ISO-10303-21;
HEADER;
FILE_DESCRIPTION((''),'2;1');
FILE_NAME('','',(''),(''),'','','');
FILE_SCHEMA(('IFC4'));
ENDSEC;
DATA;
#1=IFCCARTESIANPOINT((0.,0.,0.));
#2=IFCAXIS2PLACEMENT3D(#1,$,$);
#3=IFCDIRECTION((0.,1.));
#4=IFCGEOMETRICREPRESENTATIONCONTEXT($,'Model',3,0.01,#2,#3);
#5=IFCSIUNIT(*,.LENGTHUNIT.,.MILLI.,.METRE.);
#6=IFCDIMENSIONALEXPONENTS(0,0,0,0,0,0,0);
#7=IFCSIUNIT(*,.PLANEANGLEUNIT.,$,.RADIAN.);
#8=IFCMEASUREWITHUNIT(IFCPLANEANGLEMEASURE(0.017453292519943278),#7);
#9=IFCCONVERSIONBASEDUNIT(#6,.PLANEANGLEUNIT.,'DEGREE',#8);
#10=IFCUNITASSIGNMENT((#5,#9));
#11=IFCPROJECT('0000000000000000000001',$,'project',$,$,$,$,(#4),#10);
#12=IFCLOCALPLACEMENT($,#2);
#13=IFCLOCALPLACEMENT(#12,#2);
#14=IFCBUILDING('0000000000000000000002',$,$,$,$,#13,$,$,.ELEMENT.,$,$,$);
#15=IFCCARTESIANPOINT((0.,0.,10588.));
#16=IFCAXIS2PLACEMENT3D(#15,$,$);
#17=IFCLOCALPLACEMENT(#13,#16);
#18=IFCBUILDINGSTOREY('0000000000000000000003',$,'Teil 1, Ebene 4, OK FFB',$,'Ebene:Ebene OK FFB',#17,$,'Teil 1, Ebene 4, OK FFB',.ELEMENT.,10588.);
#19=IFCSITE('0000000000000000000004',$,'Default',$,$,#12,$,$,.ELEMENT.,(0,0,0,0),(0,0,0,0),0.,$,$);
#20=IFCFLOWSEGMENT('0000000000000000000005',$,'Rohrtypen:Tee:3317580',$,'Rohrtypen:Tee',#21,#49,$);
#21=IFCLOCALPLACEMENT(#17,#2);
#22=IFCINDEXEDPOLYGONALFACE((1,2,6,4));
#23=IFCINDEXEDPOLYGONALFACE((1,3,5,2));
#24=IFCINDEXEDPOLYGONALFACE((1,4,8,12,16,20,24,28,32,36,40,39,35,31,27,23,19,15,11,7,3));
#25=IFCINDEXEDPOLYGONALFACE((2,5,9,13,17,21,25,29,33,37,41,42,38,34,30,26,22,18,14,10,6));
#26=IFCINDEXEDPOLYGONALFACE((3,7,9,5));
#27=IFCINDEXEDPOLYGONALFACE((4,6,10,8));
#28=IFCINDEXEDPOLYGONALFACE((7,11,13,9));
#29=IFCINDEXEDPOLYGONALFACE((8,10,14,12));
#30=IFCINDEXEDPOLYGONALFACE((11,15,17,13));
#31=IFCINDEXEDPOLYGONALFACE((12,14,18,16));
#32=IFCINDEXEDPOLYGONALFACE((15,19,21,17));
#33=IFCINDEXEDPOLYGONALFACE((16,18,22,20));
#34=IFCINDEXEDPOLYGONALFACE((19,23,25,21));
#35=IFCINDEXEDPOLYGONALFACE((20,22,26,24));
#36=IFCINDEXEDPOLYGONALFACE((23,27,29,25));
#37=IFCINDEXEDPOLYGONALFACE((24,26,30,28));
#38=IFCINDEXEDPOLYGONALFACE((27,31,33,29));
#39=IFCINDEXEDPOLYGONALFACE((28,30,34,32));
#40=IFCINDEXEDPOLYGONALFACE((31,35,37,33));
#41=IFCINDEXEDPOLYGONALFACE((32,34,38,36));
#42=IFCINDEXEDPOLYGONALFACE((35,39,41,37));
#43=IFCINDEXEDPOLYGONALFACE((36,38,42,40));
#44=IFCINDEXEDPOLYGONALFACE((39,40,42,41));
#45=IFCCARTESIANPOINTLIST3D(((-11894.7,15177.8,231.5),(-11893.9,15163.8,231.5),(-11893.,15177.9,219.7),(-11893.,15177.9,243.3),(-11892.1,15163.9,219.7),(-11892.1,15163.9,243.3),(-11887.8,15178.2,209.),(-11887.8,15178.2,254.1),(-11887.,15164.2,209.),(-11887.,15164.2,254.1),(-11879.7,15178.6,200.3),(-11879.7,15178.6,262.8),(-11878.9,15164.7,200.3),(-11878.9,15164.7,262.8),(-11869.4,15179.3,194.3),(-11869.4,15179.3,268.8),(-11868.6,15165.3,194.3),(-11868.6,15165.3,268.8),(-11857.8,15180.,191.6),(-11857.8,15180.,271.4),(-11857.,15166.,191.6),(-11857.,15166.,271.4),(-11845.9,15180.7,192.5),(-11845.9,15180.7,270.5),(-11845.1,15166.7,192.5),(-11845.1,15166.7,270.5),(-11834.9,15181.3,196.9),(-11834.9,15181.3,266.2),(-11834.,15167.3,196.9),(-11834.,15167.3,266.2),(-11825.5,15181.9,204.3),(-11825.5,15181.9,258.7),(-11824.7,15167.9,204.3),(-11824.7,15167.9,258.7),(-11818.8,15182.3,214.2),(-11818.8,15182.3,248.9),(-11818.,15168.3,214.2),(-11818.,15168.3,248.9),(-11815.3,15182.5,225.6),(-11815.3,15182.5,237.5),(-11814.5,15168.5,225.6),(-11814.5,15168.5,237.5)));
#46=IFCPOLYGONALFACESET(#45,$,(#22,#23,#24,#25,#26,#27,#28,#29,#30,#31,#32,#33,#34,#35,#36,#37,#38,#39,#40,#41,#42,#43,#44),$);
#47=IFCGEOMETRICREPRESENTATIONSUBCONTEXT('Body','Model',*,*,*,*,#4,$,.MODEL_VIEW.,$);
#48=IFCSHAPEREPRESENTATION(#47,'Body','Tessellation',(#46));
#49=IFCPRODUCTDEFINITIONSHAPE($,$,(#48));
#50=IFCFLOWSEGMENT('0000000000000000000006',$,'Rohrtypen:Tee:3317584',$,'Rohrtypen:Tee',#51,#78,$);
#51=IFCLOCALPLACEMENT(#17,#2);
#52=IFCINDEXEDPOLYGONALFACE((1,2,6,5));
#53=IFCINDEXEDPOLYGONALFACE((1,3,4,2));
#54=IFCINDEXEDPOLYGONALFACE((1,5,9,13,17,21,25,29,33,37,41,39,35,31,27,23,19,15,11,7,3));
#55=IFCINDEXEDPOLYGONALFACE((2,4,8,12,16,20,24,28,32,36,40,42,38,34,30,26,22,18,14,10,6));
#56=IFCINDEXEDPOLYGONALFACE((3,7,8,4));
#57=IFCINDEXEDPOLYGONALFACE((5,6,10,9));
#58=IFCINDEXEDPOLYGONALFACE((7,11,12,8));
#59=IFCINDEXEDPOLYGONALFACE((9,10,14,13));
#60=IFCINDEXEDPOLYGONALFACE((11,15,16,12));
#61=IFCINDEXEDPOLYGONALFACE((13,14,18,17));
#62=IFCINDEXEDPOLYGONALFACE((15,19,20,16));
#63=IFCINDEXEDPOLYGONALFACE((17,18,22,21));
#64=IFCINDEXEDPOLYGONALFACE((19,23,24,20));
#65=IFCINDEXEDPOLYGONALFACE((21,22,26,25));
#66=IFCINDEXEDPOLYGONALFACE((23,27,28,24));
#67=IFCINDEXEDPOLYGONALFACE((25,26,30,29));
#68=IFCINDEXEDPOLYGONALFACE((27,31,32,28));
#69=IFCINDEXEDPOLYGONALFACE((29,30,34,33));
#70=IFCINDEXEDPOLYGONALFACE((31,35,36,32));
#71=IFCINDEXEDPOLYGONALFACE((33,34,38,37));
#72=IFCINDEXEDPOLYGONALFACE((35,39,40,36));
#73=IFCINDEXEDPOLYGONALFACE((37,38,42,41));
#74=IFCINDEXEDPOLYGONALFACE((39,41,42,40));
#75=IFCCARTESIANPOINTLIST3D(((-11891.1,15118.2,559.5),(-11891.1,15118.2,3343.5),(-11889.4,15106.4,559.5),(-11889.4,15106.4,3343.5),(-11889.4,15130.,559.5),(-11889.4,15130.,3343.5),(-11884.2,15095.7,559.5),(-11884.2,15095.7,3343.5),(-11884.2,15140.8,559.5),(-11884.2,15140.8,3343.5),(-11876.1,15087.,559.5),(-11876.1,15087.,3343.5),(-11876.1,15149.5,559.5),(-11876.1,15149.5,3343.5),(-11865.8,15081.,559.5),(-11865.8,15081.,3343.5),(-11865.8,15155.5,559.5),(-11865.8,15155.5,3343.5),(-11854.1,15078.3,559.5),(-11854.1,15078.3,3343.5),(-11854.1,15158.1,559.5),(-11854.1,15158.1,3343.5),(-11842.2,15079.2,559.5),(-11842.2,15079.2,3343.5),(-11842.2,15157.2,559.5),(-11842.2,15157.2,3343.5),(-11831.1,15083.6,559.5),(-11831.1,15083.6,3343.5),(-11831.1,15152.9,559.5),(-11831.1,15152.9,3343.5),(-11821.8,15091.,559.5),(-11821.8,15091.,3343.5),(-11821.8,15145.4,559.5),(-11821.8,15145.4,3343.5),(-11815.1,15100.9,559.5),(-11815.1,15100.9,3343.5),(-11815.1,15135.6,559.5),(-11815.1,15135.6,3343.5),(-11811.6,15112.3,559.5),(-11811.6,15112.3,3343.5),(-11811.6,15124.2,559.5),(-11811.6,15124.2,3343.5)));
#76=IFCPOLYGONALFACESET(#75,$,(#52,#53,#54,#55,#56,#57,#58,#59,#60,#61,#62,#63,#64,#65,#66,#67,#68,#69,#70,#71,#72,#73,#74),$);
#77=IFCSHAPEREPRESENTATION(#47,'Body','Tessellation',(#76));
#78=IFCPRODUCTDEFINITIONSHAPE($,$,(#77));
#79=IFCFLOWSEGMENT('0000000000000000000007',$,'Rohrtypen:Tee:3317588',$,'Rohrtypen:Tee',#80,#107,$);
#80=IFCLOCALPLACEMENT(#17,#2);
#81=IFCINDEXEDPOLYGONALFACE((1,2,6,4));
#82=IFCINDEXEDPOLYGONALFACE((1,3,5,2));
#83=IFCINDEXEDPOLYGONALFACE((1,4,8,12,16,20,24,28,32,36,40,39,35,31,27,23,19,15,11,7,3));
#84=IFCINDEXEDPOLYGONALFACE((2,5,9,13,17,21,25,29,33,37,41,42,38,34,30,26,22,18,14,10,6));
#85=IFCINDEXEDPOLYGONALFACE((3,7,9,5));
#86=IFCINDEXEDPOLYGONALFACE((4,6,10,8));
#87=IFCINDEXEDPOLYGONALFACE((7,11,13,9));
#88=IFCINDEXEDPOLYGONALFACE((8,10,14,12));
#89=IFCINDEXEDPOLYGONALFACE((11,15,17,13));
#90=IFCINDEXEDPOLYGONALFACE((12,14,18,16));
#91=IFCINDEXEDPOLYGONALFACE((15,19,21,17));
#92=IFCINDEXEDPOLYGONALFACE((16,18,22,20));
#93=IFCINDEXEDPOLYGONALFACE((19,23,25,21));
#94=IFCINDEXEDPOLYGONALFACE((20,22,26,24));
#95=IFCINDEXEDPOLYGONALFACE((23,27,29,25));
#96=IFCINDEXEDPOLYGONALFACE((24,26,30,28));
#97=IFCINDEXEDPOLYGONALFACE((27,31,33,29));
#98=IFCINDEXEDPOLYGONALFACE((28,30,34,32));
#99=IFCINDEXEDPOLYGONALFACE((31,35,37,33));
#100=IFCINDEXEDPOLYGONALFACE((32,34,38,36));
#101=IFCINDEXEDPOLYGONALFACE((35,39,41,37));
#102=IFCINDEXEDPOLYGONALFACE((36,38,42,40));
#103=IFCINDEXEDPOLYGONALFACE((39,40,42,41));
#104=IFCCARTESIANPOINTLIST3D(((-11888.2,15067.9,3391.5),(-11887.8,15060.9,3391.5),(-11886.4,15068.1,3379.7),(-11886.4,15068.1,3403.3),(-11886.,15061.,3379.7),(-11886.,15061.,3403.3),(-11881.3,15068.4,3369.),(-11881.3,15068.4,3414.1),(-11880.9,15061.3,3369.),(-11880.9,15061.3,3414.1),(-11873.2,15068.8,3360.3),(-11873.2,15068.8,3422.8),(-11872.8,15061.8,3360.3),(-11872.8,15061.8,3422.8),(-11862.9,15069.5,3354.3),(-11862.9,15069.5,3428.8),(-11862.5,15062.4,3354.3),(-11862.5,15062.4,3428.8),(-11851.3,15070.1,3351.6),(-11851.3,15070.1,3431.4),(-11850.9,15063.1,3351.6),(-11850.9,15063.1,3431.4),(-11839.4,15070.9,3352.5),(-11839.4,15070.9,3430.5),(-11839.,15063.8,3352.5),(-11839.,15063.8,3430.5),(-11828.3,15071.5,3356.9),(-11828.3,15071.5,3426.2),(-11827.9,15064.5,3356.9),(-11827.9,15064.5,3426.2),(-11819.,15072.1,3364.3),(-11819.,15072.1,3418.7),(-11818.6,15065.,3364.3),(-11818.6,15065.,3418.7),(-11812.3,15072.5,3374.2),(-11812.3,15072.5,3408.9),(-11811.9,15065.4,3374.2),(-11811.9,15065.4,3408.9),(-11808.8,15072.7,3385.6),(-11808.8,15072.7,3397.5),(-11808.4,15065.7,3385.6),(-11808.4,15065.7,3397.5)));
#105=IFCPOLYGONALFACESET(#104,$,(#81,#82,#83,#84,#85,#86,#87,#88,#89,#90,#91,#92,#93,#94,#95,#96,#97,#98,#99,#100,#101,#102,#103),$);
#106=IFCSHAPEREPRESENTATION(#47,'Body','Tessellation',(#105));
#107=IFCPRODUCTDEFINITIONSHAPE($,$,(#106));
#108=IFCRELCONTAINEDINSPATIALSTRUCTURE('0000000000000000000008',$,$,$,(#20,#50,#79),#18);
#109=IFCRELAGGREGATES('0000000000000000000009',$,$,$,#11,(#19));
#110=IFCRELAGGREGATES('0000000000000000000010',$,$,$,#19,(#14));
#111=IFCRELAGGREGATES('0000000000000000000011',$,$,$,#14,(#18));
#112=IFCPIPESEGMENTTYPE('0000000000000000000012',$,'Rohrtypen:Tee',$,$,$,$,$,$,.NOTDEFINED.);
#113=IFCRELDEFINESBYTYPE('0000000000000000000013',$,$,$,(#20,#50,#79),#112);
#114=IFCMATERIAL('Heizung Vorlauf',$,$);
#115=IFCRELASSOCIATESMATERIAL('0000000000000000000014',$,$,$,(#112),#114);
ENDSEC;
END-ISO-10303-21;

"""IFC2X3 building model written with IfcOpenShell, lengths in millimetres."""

from ifc_helpers import new_model, entity, si_unit, converted_unit, direction, frame, origin, origin_2d_with_axis, place, context, subcontext, project, spatial, circle, extrude, material, type_object, element, save


model = new_model("IFC2X3")

# Units and contexts
model_context = context("Model", 3, precision=0.01, world=origin(), true_north=direction((0.0, 1.0)))
body_context = subcontext(model_context, "Body", "Model", "MODEL_VIEW")
ifc_project = project(units=[si_unit("LENGTHUNIT", "METRE", prefix="MILLI"), converted_unit("PLANEANGLEUNIT", "DEGREE", entity("IfcPlaneAngleMeasure", 0.017453292519943278), si_unit("PLANEANGLEUNIT", "RADIAN"), dimensions=[0, 0, 0, 0, 0, 0, 0])], contexts=[model_context])

# Site, building, storey
site_placement = place(None, origin())
site = spatial("IfcSite", under=ifc_project, at=site_placement, Name="Default", CompositionType="ELEMENT", RefLatitude=(0, 0, 0, 0), RefLongitude=(0, 0, 0, 0), RefElevation=0.0)
building_placement = place(site_placement, origin())
building = spatial("IfcBuilding", under=site, at=building_placement, CompositionType="ELEMENT")
storey_placement = place(building_placement, frame((0.0, 0.0, 10588.0)))
storey = spatial("IfcBuildingStorey", under=building, at=storey_placement, Name="Teil 1, Ebene 4, OK FFB", ObjectType="Ebene:Ebene OK FFB", LongName="Teil 1, Ebene 4, OK FFB", CompositionType="ELEMENT", Elevation=10588.0)

# Flow segments
ifc_material = material(Name="Heizung Vorlauf")
pipe_segment_type = type_object("IfcPipeSegmentType", Name="Rohrtypen:Tee", PredefinedType="NOTDEFINED", material=ifc_material)
flow_segment_1_placement = place(storey_placement, origin())
element("IfcFlowSegment", 1, at=flow_segment_1_placement, inside=storey, type_object=pipe_segment_type, Name="Rohrtypen:Tee:3317580", ObjectType="Rohrtypen:Tee", context=body_context, shape_type="SweptSolid", body=[
    extrude(circle(Radius=40.0, at=origin_2d_with_axis()), frame((-11854.8, 15180.1, 231.5), z_axis=(0.059319, -0.998239, 0.0), x_axis=(-0.998239, -0.059319, 0.0)), (0.0, 0.0, 1.0), 14.0),
])
flow_segment_2_placement = place(storey_placement, origin())
element("IfcFlowSegment", 2, at=flow_segment_2_placement, inside=storey, type_object=pipe_segment_type, Name="Rohrtypen:Tee:3317584", ObjectType="Rohrtypen:Tee", context=body_context, shape_type="SweptSolid", body=[
    extrude(circle(Radius=40.0, at=origin_2d_with_axis()), frame((-11851.1, 15118.2, 559.5), z_axis=(0.0, 0.0, 1.0), x_axis=(-1.0, 0.0, 0.0)), (0.0, 0.0, 1.0), 2784.0),
])
flow_segment_3_placement = place(storey_placement, origin())
element("IfcFlowSegment", 3, at=flow_segment_3_placement, inside=storey, type_object=pipe_segment_type, Name="Rohrtypen:Tee:3317588", ObjectType="Rohrtypen:Tee", context=body_context, shape_type="SweptSolid", body=[
    extrude(circle(Radius=40.0, at=origin_2d_with_axis()), frame((-11847.9, 15063.3, 3391.5), z_axis=(-0.059319, 0.998239, 0.0), x_axis=(-0.998239, -0.059319, 0.0)), (0.0, 0.0, 1.0), 7.0),
])

save(model, "model.ifc")
